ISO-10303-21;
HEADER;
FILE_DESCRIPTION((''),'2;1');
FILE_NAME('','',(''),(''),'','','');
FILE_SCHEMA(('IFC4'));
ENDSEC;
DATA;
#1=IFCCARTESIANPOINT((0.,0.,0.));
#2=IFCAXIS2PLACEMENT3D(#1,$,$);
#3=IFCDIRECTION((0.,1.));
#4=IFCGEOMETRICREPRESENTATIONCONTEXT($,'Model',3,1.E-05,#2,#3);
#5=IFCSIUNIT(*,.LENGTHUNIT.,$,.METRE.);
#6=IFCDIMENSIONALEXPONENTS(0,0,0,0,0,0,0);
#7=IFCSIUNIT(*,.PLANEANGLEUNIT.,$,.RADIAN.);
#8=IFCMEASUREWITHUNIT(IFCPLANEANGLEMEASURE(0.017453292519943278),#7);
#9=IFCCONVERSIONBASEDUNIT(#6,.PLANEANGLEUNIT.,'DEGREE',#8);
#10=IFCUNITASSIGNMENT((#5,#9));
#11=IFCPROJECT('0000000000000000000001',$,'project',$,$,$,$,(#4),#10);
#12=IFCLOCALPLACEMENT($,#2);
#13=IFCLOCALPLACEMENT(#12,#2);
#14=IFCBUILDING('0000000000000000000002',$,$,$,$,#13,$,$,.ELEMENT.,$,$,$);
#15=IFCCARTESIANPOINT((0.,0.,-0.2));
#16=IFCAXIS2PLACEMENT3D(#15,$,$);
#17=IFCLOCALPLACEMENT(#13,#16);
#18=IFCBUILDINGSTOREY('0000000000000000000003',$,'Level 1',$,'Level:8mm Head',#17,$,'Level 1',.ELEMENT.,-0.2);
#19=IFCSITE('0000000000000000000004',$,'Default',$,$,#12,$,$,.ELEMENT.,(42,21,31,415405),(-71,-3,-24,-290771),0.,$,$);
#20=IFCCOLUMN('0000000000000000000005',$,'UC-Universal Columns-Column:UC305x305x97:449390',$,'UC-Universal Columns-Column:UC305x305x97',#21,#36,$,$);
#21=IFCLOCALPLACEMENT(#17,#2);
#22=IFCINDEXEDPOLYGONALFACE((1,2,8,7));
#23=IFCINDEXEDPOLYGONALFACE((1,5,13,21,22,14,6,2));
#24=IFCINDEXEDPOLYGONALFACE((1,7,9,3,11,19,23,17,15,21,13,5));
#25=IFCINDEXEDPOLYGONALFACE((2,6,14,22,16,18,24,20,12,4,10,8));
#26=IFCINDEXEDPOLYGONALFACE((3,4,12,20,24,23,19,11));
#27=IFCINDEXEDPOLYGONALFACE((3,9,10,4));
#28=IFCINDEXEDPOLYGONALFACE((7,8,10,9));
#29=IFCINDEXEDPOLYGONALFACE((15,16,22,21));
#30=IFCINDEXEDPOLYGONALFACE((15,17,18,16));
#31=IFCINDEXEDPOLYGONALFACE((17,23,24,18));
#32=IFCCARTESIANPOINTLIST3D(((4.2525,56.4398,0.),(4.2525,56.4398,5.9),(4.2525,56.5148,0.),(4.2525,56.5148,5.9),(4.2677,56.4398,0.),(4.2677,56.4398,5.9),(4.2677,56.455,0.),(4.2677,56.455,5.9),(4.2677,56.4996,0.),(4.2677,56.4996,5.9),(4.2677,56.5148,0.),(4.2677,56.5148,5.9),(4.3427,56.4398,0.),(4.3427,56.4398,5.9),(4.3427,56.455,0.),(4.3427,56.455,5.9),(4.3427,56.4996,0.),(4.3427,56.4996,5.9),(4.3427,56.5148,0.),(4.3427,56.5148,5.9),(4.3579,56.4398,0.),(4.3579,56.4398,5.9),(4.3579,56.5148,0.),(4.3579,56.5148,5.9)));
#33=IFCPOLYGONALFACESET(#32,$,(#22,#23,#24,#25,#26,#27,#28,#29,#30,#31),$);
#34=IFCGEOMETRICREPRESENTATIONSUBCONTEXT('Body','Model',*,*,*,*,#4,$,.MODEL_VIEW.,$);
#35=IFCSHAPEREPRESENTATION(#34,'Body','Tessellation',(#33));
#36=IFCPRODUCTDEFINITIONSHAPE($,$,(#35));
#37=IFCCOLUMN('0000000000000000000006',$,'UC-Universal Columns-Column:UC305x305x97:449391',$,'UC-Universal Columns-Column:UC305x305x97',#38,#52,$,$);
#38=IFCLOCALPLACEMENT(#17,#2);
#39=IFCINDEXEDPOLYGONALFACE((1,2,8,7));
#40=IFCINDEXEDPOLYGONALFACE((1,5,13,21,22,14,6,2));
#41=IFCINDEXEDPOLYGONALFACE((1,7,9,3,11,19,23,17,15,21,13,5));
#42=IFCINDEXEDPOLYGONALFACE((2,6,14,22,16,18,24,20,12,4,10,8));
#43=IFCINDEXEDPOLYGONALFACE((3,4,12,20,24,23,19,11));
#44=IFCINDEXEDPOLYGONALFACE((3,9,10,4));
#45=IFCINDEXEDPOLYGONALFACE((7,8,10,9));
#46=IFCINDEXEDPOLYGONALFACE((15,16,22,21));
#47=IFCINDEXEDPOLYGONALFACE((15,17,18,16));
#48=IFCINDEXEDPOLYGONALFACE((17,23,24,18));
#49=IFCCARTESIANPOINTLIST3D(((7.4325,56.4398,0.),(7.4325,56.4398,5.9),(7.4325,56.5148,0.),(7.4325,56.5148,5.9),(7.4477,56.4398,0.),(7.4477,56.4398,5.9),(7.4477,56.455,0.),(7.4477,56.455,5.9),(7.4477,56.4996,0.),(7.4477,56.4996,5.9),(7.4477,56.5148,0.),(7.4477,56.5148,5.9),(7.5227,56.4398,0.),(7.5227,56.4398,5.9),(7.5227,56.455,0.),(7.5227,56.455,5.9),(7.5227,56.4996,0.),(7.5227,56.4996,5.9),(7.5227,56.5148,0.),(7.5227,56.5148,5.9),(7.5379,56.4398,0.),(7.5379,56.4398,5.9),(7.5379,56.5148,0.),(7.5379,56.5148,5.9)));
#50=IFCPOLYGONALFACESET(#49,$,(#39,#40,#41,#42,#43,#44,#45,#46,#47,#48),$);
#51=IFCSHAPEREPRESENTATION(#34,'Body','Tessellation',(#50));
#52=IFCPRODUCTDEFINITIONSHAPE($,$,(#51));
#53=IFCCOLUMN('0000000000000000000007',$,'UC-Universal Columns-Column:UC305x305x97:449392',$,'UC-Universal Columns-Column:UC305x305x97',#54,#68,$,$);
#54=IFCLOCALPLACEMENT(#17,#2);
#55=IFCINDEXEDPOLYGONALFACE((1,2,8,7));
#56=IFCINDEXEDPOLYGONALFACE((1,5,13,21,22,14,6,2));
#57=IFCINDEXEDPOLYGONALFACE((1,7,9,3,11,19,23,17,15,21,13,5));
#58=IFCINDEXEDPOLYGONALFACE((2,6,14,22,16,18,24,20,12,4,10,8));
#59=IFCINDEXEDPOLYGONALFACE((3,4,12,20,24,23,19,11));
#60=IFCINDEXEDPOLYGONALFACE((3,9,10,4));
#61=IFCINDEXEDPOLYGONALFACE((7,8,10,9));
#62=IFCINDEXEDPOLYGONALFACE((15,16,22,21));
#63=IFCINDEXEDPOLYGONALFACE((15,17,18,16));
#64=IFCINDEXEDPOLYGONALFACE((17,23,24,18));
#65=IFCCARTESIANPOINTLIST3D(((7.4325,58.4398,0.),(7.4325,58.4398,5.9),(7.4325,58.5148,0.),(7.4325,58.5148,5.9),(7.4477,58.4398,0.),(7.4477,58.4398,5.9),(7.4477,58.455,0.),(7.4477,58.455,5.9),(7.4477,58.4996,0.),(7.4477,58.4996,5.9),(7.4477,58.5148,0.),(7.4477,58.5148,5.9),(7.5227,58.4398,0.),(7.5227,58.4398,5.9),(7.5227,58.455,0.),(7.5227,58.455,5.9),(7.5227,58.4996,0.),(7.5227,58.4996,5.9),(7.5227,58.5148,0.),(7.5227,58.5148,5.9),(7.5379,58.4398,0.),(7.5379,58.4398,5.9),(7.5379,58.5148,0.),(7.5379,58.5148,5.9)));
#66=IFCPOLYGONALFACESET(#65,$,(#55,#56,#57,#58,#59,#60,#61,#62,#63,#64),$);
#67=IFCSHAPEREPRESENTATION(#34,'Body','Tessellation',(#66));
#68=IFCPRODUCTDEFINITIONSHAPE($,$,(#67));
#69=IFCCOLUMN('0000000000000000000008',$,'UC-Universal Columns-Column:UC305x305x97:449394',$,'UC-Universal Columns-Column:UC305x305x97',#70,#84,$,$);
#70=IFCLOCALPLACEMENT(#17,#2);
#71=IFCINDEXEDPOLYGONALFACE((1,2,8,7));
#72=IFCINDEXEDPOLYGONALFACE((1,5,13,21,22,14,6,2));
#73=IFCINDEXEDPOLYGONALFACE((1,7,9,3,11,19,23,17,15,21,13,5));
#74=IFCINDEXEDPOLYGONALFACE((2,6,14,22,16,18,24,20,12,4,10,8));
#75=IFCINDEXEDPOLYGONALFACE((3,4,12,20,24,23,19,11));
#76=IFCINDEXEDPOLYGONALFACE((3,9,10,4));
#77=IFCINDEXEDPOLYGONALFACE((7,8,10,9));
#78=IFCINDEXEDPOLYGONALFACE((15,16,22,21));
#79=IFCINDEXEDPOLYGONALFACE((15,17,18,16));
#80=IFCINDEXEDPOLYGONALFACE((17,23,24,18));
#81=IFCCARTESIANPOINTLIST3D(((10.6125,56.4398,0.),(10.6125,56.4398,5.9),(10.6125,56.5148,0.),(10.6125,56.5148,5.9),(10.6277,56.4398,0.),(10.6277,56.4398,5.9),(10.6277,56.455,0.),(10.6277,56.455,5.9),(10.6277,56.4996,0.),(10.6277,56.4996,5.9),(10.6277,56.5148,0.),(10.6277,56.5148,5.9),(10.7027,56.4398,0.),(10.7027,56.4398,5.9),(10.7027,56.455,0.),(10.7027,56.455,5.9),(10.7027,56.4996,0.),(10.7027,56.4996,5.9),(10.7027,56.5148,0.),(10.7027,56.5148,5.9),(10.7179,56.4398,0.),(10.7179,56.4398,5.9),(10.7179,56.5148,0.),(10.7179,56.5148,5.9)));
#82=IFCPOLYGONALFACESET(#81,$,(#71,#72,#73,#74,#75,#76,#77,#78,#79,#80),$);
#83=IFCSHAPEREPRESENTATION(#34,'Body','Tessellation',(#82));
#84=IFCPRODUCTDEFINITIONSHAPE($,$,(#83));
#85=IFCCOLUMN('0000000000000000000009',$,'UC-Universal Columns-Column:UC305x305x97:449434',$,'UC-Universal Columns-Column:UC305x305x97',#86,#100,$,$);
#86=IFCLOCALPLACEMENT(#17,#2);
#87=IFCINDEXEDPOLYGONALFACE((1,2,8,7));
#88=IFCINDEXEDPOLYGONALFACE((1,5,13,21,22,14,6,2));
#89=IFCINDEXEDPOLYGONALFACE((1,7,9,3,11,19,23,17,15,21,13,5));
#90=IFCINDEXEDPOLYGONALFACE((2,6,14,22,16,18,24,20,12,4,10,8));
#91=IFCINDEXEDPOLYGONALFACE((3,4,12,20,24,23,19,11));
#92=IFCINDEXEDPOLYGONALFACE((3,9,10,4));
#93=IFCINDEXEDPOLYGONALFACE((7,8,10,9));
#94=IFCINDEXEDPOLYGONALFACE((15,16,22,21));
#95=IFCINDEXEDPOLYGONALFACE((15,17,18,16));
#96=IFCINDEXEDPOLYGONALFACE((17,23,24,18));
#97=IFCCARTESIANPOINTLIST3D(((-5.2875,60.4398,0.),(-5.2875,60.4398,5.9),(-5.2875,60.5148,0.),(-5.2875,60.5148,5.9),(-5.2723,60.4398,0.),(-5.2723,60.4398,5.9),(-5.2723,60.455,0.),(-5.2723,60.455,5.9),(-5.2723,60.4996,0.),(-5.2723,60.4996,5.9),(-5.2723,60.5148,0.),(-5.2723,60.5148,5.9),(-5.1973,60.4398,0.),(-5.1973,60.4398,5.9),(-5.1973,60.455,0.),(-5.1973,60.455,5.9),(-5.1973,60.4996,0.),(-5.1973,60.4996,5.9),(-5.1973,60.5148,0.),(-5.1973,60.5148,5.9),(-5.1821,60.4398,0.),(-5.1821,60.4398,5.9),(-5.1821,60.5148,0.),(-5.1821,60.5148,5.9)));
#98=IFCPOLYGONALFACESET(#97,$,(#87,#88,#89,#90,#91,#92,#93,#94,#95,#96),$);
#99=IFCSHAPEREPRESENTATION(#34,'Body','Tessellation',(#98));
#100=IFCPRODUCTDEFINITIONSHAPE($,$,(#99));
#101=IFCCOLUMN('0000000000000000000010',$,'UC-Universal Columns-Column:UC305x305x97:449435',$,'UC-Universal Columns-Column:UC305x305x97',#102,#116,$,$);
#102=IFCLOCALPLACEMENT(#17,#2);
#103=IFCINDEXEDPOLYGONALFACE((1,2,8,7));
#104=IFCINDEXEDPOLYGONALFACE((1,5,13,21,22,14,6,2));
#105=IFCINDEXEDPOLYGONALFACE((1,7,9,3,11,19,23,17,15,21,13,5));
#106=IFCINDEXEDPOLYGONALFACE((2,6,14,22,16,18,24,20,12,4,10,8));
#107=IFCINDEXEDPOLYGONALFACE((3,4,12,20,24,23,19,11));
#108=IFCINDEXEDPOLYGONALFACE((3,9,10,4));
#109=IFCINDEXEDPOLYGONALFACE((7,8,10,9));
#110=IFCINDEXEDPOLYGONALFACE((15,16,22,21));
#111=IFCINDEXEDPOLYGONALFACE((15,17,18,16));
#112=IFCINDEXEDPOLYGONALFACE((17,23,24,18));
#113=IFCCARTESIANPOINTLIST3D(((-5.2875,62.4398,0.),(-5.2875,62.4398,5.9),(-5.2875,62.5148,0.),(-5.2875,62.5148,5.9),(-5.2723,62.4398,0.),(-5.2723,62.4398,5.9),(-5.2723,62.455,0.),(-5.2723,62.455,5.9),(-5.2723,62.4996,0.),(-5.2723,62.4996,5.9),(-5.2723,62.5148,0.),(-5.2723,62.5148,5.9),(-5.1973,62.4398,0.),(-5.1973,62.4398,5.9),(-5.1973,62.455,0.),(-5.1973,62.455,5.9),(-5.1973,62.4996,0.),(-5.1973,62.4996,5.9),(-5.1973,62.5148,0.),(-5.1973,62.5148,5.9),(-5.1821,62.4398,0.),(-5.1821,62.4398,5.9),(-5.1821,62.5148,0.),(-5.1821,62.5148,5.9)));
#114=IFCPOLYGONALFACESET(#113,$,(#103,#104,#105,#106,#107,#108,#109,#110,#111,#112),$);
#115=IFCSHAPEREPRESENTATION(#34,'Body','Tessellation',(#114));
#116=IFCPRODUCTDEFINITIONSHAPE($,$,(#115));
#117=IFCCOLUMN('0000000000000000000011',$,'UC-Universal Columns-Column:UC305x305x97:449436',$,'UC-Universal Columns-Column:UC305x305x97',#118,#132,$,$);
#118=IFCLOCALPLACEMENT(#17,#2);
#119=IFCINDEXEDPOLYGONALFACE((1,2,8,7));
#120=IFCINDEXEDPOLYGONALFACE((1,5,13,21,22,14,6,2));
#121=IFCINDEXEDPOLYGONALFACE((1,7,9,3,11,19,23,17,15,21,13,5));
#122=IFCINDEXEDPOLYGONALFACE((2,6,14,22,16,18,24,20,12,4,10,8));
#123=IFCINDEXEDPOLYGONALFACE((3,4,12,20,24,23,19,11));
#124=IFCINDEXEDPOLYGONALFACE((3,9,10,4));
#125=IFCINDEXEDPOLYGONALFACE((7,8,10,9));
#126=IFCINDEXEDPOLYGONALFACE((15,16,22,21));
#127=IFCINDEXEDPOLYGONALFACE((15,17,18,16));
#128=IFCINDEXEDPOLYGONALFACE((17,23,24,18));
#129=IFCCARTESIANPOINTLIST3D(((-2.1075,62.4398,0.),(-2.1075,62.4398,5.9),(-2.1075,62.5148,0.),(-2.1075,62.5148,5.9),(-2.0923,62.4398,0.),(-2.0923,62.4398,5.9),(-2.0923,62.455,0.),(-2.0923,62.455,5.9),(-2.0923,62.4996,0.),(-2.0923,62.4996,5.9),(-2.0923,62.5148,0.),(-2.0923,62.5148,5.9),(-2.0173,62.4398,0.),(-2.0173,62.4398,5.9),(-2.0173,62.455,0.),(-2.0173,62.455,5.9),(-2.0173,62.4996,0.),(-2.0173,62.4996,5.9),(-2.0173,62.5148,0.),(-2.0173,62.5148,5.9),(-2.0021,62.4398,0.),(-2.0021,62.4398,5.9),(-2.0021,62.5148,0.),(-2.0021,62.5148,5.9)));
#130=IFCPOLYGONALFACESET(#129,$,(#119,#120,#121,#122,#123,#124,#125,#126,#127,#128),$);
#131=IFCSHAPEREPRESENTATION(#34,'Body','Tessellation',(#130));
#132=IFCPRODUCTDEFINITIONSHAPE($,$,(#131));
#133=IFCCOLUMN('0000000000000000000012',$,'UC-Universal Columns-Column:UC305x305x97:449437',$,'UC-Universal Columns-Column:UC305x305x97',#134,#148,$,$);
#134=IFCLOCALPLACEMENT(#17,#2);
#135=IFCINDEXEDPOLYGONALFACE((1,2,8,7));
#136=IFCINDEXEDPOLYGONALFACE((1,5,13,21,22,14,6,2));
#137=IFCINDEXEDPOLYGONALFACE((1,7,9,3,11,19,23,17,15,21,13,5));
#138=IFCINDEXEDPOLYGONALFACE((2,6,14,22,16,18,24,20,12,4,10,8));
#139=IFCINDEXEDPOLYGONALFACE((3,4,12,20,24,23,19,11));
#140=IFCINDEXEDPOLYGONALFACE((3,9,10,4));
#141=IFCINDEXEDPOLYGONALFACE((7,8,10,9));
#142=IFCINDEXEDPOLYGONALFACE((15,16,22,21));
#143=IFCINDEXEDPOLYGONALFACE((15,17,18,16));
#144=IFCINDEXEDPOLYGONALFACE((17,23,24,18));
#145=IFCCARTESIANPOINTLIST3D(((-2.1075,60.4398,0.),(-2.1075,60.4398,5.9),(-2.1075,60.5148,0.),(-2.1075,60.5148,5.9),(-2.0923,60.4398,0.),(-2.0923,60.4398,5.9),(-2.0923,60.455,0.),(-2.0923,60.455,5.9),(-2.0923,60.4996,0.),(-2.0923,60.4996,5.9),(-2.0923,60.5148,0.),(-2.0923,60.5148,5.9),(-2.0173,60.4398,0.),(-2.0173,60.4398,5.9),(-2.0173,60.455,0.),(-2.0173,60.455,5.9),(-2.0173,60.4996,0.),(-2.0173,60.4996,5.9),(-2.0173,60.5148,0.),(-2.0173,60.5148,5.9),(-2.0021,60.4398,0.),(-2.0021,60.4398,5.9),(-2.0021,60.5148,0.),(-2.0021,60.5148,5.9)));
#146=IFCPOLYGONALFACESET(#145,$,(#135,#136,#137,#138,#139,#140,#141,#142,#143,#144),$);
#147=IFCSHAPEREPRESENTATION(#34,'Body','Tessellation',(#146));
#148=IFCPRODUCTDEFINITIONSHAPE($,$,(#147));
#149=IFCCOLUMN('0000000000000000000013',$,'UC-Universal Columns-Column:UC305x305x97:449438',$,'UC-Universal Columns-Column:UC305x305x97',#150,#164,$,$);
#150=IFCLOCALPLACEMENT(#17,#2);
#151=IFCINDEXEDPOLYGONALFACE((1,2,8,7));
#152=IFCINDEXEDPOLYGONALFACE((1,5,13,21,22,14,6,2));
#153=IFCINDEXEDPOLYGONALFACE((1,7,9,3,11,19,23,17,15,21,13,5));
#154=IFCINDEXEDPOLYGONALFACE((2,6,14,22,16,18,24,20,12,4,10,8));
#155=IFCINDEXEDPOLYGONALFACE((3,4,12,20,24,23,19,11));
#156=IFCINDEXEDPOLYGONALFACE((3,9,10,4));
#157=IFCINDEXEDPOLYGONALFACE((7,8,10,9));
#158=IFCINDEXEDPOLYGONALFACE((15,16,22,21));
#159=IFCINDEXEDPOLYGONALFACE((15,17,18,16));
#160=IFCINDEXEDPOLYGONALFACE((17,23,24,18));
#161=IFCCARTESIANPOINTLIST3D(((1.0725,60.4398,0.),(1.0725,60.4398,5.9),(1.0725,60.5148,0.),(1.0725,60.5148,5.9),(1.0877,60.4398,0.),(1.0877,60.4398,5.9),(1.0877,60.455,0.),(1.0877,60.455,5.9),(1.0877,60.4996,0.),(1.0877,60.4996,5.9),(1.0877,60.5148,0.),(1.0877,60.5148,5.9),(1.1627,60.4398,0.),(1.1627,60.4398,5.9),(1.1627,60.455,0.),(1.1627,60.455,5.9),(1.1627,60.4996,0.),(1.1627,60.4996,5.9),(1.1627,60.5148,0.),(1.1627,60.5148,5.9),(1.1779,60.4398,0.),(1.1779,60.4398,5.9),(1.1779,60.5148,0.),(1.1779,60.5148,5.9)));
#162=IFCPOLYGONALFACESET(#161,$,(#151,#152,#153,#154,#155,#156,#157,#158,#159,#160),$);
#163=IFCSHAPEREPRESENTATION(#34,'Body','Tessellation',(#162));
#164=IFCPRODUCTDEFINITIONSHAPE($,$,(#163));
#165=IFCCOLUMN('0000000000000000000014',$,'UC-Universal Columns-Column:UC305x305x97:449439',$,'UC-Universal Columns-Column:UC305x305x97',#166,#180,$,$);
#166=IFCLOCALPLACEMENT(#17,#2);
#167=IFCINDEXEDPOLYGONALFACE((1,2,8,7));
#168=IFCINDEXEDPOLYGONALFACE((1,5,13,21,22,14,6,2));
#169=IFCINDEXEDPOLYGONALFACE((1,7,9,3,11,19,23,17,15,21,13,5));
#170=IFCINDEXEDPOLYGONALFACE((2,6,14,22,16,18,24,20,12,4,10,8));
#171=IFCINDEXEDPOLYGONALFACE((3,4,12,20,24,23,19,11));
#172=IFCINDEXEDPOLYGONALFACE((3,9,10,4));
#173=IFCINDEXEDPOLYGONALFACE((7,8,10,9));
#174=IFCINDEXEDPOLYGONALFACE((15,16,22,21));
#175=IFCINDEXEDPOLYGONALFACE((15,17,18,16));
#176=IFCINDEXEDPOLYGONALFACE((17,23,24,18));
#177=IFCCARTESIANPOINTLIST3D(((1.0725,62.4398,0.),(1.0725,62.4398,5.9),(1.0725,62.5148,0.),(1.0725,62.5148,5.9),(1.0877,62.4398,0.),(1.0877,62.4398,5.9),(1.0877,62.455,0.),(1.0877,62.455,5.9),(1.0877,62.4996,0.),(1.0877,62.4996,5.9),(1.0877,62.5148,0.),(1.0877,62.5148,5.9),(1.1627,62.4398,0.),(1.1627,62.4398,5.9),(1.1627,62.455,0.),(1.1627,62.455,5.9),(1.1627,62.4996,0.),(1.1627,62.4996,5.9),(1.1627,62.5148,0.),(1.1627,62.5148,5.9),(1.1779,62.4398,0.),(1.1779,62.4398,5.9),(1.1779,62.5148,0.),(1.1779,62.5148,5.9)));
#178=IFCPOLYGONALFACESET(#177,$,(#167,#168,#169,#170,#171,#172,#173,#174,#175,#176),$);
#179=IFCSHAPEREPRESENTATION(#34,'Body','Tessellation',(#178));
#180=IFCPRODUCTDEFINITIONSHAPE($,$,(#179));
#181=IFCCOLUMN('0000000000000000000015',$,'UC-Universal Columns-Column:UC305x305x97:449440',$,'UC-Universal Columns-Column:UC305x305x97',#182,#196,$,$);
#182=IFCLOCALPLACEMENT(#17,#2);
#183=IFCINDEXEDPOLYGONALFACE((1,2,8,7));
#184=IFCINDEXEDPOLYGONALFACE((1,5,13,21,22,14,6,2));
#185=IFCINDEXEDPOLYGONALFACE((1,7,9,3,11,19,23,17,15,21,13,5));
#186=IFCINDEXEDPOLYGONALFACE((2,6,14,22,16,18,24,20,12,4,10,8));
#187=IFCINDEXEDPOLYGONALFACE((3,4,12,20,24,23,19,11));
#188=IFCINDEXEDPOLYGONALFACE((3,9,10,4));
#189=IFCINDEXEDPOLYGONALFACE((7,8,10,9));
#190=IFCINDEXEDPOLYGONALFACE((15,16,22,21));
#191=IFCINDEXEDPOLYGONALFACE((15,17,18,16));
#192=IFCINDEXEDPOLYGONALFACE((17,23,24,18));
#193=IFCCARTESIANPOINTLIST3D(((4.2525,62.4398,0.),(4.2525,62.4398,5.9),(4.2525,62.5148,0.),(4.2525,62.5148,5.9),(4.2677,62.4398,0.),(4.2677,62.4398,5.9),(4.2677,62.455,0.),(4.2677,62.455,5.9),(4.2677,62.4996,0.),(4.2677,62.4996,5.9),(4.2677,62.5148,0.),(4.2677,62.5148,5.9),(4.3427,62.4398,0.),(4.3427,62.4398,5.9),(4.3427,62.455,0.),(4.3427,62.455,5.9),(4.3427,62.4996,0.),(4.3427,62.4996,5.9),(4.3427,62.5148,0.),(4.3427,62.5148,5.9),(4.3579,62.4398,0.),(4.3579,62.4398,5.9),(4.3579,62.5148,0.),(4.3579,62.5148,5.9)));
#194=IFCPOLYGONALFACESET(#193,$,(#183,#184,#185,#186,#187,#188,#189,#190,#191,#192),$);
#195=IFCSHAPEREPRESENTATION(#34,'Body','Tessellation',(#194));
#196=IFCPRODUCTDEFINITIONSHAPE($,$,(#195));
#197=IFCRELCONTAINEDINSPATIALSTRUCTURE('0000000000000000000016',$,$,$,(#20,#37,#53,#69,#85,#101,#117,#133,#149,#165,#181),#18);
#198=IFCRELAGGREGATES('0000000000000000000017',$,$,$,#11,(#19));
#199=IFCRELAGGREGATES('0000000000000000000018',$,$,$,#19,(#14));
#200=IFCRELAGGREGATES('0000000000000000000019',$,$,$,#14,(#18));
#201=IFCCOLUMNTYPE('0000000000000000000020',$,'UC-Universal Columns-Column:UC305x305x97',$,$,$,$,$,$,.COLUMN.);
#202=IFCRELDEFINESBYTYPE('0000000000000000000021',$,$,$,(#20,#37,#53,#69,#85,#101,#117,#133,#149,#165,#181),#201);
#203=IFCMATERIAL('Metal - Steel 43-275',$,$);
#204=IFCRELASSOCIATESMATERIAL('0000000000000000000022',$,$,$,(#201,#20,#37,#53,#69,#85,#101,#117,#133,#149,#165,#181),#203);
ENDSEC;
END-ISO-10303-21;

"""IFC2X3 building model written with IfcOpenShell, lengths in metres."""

from ifc_helpers import new_model, entity, si_unit, converted_unit, direction, frame, frame_2d, origin, place, context, subcontext, project, spatial, polyline, circle_curve, parameter, trimmed, segment, composite_curve, outline, extrude, source, transform, mapped, material, type_object, type_shapes, element, save


model = new_model("IFC2X3")

# Units and contexts
model_context = context("Model", 3, precision=1e-05, world=origin(), true_north=direction((0.0, 1.0)))
body_context = subcontext(model_context, "Body", "Model", "MODEL_VIEW")
ifc_project = project(units=[si_unit("LENGTHUNIT", "METRE"), converted_unit("PLANEANGLEUNIT", "DEGREE", entity("IfcPlaneAngleMeasure", 0.017453292519943278), si_unit("PLANEANGLEUNIT", "RADIAN"), dimensions=[0, 0, 0, 0, 0, 0, 0])], contexts=[model_context])

# Site, building, storey
site_placement = place(None, origin())
site = spatial("IfcSite", under=ifc_project, at=site_placement, Name="Default", CompositionType="ELEMENT", RefLatitude=(42, 21, 31, 415405), RefLongitude=(-71, -3, -24, -290771), RefElevation=0.0)
building_placement = place(site_placement, origin())
building = spatial("IfcBuilding", under=site, at=building_placement, CompositionType="ELEMENT")
storey_placement = place(building_placement, frame((0.0, 0.0, -0.2)))
storey = spatial("IfcBuildingStorey", under=building, at=storey_placement, Name="Level 1", ObjectType="Level:8mm Head", LongName="Level 1", CompositionType="ELEMENT", Elevation=-0.2)

# Columns
ifc_material = material(Name="Metal - Steel 43-275")
column_type = type_object("IfcColumnType", Name="UC-Universal Columns-Column:UC305x305x97", PredefinedType="COLUMN", material=ifc_material)
shared_shape = source(origin(), body_context, "Body", "SweptSolid", [
    extrude(outline(composite_curve([segment(polyline([(-0.0375, -0.0375), (0.0375, -0.0375)]), True, "CONTINUOUS"), segment(polyline([(0.0375, -0.0375), (0.0527, -0.0375)]), True, "CONTINUOUS"), segment(trimmed(circle_curve(frame_2d((0.0527, -0.0223), x_axis=(-1.0, 0.0)), 0.0152), [parameter(0.0)], [parameter(90.0)], True, "PARAMETER"), False, "CONTINUOUS"), segment(polyline([(0.0375, -0.0223), (0.0375, 0.0223)]), True, "CONTINUOUS"), segment(trimmed(circle_curve(frame_2d((0.0527, 0.0223), x_axis=(-1.0, 0.0)), 0.0152), [parameter(270.0)], [parameter(0.0)], True, "PARAMETER"), False, "CONTINUOUS"), segment(polyline([(0.0527, 0.0375), (0.0375, 0.0375)]), True, "CONTINUOUS"), segment(polyline([(0.0375, 0.0375), (-0.0375, 0.0375)]), True, "CONTINUOUS"), segment(polyline([(-0.0375, 0.0375), (-0.0527, 0.0375)]), True, "CONTINUOUS"), segment(trimmed(circle_curve(frame_2d((-0.0527, 0.0223), x_axis=(-1.0, 0.0)), 0.0152), [parameter(180.0)], [parameter(270.0)], True, "PARAMETER"), False, "CONTINUOUS"), segment(polyline([(-0.0375, 0.0223), (-0.0375, -0.0223)]), True, "CONTINUOUS"), segment(trimmed(circle_curve(frame_2d((-0.0527, -0.0223), x_axis=(-1.0, 0.0)), 0.0152), [parameter(90.0)], [parameter(180.0)], True, "PARAMETER"), False, "CONTINUOUS"), segment(polyline([(-0.0527, -0.0375), (-0.0375, -0.0375)]), True, "CONTINUOUS")], self_intersect=False)), frame((0.0, 0.0, -0.2), z_axis=(0.0, 0.0, 1.0), x_axis=(-1.0, 0.0, 0.0)), (0.0, 0.0, 1.0), 5.9),
])
type_shapes(column_type, [shared_shape])
for number, where, z_axis, x_axis, name in (
    (1, (4.3052, 56.4773, 0.2), (0.0, 0.0, 1.0), (-1.0, 0.0, 0.0), "UC-Universal Columns-Column:UC305x305x97:449390"),
    (2, (7.4852, 56.4773, 0.2), (0.0, 0.0, 1.0), (-1.0, 0.0, 0.0), "UC-Universal Columns-Column:UC305x305x97:449391"),
    (3, (7.4852, 58.4773, 0.2), (0.0, 0.0, 1.0), (-1.0, 0.0, 0.0), "UC-Universal Columns-Column:UC305x305x97:449392"),
    (4, (10.6652, 56.4773, 0.2), (0.0, 0.0, 1.0), (-1.0, 0.0, 0.0), "UC-Universal Columns-Column:UC305x305x97:449394"),
    (5, (-5.2348, 60.4773, 0.2), (0.0, 0.0, 1.0), (-1.0, 0.0, 0.0), "UC-Universal Columns-Column:UC305x305x97:449434"),
    (6, (-5.2348, 62.4773, 0.2), (0.0, 0.0, 1.0), (-1.0, 0.0, 0.0), "UC-Universal Columns-Column:UC305x305x97:449435"),
    (7, (-2.0548, 62.4773, 0.2), (0.0, 0.0, 1.0), (-1.0, 0.0, 0.0), "UC-Universal Columns-Column:UC305x305x97:449436"),
    (8, (-2.0548, 60.4773, 0.2), (0.0, 0.0, 1.0), (-1.0, 0.0, 0.0), "UC-Universal Columns-Column:UC305x305x97:449437"),
    (9, (1.1252, 60.4773, 0.2), (0.0, 0.0, 1.0), (-1.0, 0.0, 0.0), "UC-Universal Columns-Column:UC305x305x97:449438"),
    (10, (1.1252, 62.4773, 0.2), (0.0, 0.0, 1.0), (-1.0, 0.0, 0.0), "UC-Universal Columns-Column:UC305x305x97:449439"),
    (11, (4.3052, 62.4773, 0.2), (0.0, 0.0, 1.0), (-1.0, 0.0, 0.0), "UC-Universal Columns-Column:UC305x305x97:449440"),
):
    element("IfcColumn", number, at=place(storey_placement, frame(where, z_axis=z_axis, x_axis=x_axis)), inside=storey, type_object=column_type, material=ifc_material, Name=name, ObjectType="UC-Universal Columns-Column:UC305x305x97", context=body_context, shape_type="MappedRepresentation", body=[
        mapped(shared_shape, transform((0.0, 0.0, 0.0), scale=1.0)),
    ])

save(model, "model.ifc")
